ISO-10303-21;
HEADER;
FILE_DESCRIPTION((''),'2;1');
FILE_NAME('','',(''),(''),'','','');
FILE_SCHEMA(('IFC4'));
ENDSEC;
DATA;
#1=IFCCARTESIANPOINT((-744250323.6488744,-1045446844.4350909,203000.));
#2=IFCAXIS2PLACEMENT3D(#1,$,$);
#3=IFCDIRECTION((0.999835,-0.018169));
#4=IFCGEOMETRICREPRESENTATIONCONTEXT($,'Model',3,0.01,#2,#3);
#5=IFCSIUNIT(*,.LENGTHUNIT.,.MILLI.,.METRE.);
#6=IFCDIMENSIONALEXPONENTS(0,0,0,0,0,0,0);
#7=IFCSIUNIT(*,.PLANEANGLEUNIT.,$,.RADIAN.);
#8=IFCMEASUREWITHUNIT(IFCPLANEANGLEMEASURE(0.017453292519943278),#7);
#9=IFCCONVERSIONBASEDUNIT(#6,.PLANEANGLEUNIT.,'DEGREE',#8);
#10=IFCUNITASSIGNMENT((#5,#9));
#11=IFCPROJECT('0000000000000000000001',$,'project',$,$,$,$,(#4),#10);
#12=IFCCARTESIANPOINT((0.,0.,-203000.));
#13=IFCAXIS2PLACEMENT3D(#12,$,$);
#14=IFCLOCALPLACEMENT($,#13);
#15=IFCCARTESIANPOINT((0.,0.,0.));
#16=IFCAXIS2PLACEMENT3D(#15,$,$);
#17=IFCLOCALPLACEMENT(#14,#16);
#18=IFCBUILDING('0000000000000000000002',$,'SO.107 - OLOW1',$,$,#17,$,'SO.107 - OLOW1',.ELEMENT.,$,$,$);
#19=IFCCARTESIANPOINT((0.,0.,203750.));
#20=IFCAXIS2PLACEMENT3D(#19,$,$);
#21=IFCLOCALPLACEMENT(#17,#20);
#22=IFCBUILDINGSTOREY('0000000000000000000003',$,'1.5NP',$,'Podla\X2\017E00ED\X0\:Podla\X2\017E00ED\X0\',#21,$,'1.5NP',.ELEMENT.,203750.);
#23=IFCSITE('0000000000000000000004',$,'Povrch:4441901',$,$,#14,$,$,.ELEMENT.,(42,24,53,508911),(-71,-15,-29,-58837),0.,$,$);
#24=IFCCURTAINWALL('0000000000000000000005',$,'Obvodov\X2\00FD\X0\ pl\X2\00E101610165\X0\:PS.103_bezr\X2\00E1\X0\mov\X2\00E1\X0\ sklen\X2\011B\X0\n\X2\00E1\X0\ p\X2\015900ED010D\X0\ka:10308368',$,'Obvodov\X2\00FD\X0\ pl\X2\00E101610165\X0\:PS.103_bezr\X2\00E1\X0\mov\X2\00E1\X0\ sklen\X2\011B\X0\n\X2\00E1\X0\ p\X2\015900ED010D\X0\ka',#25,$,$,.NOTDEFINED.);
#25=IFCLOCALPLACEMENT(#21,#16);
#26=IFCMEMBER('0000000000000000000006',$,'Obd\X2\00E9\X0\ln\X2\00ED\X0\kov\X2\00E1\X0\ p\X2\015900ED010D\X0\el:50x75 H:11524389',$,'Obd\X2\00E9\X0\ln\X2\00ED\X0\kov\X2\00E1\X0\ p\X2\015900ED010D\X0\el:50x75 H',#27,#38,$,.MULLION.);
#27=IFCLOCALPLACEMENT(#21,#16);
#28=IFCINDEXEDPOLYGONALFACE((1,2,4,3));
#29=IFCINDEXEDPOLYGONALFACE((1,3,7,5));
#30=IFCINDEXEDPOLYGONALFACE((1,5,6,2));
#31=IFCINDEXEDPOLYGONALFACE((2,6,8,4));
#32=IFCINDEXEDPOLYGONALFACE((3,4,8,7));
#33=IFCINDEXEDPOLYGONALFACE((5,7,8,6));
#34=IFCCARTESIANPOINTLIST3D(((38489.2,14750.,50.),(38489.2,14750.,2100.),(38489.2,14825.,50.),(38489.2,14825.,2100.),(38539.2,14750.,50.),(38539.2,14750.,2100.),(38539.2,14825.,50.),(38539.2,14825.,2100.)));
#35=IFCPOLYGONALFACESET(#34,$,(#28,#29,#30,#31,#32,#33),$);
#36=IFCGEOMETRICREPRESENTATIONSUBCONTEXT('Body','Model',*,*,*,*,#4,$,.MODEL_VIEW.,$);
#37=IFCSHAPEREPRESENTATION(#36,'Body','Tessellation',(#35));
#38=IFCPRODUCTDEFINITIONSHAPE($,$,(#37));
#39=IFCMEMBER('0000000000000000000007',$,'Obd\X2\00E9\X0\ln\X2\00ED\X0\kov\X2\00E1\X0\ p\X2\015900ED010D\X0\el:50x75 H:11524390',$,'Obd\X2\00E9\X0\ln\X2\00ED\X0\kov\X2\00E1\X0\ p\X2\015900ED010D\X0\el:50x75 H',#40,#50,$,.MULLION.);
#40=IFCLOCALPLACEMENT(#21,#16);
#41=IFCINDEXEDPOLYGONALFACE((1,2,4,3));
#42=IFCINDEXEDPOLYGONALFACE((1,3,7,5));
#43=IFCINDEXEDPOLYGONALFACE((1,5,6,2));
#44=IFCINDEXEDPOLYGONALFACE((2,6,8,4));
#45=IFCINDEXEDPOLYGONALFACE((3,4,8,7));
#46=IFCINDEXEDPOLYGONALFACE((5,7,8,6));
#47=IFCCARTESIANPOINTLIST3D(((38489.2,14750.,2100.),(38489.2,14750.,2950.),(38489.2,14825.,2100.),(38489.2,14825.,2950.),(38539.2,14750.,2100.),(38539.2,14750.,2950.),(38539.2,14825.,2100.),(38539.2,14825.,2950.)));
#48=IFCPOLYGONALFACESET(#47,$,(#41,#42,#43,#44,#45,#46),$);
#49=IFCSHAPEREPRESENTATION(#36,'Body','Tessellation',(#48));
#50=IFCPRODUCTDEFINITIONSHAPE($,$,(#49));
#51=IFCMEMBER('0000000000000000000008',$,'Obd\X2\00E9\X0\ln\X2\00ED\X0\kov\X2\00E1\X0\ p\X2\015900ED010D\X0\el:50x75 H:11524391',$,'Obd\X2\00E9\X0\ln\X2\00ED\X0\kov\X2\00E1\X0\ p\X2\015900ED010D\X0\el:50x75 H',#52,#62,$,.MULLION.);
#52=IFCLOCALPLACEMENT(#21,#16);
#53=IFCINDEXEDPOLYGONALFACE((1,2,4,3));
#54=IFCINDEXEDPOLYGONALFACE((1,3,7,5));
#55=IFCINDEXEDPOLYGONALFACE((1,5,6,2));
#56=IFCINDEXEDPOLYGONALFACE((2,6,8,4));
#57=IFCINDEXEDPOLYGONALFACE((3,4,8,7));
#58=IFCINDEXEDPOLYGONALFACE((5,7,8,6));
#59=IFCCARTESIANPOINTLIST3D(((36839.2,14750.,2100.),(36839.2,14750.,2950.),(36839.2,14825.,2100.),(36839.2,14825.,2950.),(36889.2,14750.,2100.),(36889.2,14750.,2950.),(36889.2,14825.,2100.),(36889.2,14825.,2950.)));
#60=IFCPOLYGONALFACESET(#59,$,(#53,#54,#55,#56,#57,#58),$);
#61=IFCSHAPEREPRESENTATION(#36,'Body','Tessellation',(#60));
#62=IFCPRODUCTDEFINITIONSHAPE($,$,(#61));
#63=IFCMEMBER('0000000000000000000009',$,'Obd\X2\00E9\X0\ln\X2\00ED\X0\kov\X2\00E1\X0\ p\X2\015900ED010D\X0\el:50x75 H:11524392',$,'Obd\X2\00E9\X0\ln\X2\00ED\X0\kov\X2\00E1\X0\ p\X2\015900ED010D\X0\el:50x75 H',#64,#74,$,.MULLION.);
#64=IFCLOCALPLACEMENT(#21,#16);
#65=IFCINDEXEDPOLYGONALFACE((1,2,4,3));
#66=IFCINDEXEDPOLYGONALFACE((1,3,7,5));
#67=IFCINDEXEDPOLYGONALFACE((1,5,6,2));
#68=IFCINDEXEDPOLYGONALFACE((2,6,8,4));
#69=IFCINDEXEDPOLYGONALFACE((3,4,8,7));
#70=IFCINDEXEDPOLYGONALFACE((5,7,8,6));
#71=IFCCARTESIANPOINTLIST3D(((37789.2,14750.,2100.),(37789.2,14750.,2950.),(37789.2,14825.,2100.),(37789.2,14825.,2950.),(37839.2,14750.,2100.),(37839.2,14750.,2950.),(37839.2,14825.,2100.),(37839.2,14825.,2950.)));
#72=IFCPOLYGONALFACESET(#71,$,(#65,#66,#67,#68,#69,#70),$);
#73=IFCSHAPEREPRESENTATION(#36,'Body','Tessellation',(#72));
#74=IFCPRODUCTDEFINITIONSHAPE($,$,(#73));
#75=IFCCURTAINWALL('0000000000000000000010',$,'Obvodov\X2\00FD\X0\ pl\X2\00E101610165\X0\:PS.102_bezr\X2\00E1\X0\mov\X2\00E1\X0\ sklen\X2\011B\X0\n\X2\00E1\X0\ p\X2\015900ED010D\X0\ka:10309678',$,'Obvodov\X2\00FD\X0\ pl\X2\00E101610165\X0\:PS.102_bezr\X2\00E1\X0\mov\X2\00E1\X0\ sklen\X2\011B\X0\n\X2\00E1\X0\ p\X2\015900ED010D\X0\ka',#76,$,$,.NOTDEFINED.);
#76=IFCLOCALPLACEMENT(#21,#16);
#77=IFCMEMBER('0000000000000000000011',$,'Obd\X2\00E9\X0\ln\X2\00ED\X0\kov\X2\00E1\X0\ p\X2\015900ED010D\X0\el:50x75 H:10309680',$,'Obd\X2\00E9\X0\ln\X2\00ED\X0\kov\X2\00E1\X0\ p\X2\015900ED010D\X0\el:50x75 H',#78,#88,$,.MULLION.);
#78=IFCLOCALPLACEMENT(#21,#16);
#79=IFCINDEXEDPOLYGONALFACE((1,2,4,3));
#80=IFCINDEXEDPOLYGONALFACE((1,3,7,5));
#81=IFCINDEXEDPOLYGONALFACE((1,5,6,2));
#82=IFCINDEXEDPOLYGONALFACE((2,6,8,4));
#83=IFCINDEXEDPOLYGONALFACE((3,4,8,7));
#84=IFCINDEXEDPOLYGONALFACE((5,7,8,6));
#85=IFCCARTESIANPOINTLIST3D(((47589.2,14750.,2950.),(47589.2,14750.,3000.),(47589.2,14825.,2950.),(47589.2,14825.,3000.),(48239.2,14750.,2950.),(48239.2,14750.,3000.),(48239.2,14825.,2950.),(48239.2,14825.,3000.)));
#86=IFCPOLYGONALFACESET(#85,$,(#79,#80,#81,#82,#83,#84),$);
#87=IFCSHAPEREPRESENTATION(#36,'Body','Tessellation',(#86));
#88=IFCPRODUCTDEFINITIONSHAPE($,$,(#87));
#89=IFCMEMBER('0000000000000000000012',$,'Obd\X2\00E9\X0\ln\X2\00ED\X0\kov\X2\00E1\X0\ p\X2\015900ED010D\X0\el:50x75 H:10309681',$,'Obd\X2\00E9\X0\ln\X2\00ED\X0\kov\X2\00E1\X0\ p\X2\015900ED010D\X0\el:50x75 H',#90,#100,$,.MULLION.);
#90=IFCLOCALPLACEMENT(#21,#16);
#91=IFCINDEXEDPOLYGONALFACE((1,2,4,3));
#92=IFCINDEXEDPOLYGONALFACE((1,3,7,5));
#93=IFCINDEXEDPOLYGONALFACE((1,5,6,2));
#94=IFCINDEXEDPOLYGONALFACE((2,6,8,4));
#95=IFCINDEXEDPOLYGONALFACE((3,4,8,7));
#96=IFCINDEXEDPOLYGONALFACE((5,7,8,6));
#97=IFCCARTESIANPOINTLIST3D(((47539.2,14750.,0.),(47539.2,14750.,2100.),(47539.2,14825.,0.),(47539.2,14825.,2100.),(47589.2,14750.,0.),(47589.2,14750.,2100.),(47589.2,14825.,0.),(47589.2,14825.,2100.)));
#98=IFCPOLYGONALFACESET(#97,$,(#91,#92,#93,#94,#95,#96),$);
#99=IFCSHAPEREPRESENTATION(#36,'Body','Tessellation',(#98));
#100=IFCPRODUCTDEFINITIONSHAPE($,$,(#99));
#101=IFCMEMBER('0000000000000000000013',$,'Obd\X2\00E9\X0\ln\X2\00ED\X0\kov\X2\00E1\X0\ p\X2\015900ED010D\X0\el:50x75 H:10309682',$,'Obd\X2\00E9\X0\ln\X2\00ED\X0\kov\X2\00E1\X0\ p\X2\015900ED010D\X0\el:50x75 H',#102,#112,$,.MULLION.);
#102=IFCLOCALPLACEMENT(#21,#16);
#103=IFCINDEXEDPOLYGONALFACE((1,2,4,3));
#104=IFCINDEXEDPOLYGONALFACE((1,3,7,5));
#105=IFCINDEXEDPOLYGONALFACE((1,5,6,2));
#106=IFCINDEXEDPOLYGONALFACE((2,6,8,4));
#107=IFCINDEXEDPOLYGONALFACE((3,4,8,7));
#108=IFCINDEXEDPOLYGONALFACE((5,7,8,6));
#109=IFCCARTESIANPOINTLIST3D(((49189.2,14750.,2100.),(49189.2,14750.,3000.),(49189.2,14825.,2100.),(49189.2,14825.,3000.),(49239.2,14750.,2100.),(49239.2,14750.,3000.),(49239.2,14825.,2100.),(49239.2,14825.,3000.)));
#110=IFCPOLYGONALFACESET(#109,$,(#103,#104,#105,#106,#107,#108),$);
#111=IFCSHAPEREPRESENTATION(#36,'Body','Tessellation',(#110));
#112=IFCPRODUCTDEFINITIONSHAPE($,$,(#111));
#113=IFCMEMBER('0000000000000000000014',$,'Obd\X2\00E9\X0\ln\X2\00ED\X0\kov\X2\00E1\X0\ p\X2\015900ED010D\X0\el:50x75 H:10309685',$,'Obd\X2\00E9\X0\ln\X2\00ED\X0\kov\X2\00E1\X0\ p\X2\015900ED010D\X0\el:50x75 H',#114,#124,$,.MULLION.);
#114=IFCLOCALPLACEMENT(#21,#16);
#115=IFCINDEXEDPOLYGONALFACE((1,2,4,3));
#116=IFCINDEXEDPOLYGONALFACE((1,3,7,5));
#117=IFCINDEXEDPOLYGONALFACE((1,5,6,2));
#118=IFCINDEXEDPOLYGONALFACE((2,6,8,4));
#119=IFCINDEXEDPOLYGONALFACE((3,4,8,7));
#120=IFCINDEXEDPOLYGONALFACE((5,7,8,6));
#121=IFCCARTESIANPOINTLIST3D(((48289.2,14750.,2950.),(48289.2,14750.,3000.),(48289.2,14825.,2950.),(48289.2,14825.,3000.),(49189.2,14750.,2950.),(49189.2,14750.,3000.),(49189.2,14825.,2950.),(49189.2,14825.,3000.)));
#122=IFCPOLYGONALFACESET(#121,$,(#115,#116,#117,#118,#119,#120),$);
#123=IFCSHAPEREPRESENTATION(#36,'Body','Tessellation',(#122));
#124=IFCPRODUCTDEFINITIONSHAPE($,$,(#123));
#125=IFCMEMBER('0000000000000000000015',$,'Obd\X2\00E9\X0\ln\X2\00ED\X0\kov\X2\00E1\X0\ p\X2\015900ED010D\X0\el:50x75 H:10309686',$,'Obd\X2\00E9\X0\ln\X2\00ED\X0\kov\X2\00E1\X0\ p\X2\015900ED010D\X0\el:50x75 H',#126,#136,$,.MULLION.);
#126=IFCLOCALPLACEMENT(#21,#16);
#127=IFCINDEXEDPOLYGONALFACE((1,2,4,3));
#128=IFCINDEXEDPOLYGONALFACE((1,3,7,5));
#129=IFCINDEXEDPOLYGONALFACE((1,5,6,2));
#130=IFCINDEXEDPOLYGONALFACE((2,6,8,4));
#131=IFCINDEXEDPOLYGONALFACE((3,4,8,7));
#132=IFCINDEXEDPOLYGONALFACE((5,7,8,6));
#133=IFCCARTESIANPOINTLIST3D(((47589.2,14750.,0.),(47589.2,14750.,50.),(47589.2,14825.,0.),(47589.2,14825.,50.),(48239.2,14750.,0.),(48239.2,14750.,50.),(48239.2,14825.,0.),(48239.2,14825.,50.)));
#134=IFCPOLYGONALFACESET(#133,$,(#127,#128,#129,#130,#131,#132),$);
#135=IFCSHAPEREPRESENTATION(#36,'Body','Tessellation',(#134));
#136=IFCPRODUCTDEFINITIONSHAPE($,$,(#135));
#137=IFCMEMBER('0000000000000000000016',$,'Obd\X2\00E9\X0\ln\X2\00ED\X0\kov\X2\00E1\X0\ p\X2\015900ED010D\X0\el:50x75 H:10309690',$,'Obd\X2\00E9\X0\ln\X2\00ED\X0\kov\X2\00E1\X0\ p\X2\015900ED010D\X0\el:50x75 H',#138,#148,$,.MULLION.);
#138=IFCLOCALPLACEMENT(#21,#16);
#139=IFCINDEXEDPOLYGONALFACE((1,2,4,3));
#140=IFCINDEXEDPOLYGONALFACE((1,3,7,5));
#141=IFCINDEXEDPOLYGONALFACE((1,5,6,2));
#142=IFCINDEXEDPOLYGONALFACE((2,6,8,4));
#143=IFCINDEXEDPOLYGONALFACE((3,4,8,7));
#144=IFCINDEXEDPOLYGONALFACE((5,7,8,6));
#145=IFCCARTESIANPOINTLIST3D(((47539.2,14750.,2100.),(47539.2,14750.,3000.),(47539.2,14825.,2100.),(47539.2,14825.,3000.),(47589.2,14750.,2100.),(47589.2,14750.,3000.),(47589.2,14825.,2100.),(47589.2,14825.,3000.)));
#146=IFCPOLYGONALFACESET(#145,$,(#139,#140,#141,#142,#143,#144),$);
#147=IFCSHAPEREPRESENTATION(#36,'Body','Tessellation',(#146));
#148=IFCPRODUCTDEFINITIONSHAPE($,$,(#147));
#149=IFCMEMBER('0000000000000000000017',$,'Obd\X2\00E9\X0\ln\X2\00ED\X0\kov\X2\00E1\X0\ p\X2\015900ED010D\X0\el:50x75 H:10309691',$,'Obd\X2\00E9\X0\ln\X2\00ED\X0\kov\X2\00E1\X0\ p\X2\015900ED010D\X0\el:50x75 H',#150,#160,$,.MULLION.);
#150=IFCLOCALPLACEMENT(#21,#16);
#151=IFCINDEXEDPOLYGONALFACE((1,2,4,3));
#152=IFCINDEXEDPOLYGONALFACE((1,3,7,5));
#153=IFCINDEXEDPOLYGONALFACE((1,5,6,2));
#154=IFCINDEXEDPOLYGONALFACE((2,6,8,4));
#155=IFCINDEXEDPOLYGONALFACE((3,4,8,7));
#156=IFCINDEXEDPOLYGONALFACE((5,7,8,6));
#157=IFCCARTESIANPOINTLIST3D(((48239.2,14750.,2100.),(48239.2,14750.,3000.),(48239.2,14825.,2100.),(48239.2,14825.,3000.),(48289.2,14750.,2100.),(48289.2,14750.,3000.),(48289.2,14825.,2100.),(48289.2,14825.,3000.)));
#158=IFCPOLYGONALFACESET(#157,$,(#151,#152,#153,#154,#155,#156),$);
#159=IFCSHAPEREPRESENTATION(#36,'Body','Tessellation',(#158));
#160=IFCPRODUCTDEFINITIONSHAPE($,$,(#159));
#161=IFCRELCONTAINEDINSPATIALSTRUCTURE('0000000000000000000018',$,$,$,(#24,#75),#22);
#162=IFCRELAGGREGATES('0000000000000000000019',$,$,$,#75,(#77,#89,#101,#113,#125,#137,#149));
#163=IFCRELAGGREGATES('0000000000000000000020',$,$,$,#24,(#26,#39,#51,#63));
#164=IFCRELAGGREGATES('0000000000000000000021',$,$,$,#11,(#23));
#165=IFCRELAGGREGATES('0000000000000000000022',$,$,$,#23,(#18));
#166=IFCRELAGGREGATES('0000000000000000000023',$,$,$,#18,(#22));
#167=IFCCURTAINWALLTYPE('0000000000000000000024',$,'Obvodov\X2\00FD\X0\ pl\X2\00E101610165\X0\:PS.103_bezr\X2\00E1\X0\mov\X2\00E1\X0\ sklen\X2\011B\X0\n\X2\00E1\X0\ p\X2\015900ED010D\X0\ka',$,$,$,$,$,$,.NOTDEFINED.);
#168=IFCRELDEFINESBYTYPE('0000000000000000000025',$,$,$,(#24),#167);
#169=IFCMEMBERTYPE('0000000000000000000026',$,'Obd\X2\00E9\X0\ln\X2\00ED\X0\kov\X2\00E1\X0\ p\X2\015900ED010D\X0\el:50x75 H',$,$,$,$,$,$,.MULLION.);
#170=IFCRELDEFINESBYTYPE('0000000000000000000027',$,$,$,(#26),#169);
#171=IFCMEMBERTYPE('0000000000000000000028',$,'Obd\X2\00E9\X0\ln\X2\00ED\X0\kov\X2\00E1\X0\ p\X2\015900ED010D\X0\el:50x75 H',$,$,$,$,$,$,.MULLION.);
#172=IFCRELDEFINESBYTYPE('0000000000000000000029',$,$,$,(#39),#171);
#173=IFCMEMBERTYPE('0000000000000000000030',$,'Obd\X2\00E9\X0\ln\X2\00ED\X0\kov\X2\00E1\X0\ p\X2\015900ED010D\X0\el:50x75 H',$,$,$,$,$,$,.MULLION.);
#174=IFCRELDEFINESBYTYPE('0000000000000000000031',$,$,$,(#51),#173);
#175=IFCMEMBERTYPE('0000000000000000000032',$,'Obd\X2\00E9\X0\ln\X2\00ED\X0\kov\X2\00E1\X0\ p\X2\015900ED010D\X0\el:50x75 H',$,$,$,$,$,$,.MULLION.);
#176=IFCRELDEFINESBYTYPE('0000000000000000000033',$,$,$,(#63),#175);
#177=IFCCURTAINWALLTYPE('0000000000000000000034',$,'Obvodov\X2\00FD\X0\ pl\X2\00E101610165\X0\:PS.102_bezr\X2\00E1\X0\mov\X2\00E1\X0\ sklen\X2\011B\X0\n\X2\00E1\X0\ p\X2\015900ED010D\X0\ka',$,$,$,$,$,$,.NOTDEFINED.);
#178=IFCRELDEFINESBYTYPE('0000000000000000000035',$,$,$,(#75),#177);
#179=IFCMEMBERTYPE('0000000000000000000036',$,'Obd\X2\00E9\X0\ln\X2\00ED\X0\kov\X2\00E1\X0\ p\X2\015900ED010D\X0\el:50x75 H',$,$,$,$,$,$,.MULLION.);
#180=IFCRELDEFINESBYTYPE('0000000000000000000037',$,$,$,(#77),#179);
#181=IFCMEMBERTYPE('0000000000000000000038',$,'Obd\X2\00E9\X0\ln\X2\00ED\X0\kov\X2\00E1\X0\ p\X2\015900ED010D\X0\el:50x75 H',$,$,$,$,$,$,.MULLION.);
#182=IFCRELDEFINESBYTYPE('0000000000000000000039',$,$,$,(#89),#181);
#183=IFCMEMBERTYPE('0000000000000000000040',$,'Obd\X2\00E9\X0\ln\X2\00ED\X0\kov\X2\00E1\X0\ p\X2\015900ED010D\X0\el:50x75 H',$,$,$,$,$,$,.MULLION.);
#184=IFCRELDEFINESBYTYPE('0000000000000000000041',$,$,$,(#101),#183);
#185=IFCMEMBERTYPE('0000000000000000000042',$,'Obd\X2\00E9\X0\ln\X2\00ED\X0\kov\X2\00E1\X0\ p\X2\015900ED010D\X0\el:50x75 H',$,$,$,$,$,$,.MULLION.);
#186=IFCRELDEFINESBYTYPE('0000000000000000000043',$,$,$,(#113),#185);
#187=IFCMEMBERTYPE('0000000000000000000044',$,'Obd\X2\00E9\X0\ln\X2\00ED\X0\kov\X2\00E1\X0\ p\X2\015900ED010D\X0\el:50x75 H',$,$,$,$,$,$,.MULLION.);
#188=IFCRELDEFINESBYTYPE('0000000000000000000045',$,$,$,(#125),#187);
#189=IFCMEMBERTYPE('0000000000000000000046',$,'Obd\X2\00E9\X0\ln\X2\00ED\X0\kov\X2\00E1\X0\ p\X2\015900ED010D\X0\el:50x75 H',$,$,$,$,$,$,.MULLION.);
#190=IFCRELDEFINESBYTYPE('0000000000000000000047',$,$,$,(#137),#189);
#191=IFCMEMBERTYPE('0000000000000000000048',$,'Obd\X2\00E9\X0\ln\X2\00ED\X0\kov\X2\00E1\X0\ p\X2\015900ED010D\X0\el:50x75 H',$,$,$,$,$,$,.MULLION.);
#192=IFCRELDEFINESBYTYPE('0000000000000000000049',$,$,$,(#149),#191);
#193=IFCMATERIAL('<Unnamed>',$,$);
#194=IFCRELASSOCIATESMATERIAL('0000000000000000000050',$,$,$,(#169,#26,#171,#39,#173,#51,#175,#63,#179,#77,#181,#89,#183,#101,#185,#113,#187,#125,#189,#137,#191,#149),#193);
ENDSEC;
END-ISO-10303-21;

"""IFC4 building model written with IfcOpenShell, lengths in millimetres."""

from ifc_helpers import new_model, entity, si_unit, converted_unit, direction, frame, origin, place, context, subcontext, project, spatial, indexed_curve, outline, extrude, source, transform, mapped, material, type_object, type_shapes, element, aggregate, save


model = new_model("IFC4")

# Units and contexts
model_context = context("Model", 3, precision=0.01, world=frame((-744250323.6488744, -1045446844.4350909, 203000.0)), true_north=direction((0.999835, -0.018169)))
body_context = subcontext(model_context, "Body", "Model", "MODEL_VIEW")
ifc_project = project(units=[si_unit("LENGTHUNIT", "METRE", prefix="MILLI"), converted_unit("PLANEANGLEUNIT", "DEGREE", entity("IfcPlaneAngleMeasure", 0.017453292519943278), si_unit("PLANEANGLEUNIT", "RADIAN"), dimensions=[0, 0, 0, 0, 0, 0, 0])], contexts=[model_context])

# Site, building, storey
site_placement = place(None, frame((0.0, 0.0, -203000.0)))
site = spatial("IfcSite", under=ifc_project, at=site_placement, Name="Povrch:4441901", CompositionType="ELEMENT", RefLatitude=(42, 24, 53, 508911), RefLongitude=(-71, -15, -29, -58837), RefElevation=0.0)
building_placement = place(site_placement, origin())
building = spatial("IfcBuilding", under=site, at=building_placement, Name="SO.107 - OLOW1", LongName="SO.107 - OLOW1", CompositionType="ELEMENT")
storey_placement = place(building_placement, frame((0.0, 0.0, 203750.0)))
storey = spatial("IfcBuildingStorey", under=building, at=storey_placement, Name="1.5NP", ObjectType="Podlaží:Podlaží", LongName="1.5NP", CompositionType="ELEMENT", Elevation=203750.0)

# Curtain walls, members
ifc_material_1 = material(Name="<Unnamed>")
curtain_wall_type_1 = type_object("IfcCurtainWallType", Name="Obvodový plášť:PS.103_bezrámová skleněná příčka", PredefinedType="NOTDEFINED")
curtain_wall_1_placement = place(storey_placement, frame((0.0, 0.0, -203750.0)))
curtain_wall_1 = element("IfcCurtainWall", 1, at=curtain_wall_1_placement, inside=storey, type_object=curtain_wall_type_1, Name="Obvodový plášť:PS.103_bezrámová skleněná příčka:10308368", ObjectType="Obvodový plášť:PS.103_bezrámová skleněná příčka", PredefinedType="NOTDEFINED")
member_type_1 = type_object("IfcMemberType", Name="Obdélníková příčel:50x75 H", PredefinedType="MULLION", material=ifc_material_1)
shared_shape_1 = source(origin(), body_context, "Body", "SweptSolid", [
    extrude(outline(indexed_curve([(-25.0, -37.5), (25.0, -37.5), (25.0, 37.5), (-25.0, 37.5), (-25.0, -37.5)], self_intersect=False)), frame((-25.0, -37.5, -2050.0), z_axis=(0.0, 0.0, 1.0), x_axis=(-1.0, 0.0, 0.0)), (0.0, 0.0, 1.0), 2050.0),
])
type_shapes(member_type_1, [shared_shape_1])
member_1_placement = place(curtain_wall_1_placement, frame((38539.2, 14750.0, 203800.0), z_axis=(0.0, 0.0, -1.0), x_axis=(1.0, 0.0, 0.0)))
member_1 = element("IfcMember", 2, at=member_1_placement, type_object=member_type_1, material=ifc_material_1, Name="Obdélníková příčel:50x75 H:11524389", ObjectType="Obdélníková příčel:50x75 H", PredefinedType="MULLION", context=body_context, shape_type="MappedRepresentation", body=[
    mapped(shared_shape_1, transform((0.0, 0.0, 0.0), scale=1.0)),
])
member_type_2 = type_object("IfcMemberType", Name="Obdélníková příčel:50x75 H", PredefinedType="MULLION", material=ifc_material_1)
shared_shape_2 = source(origin(), body_context, "Body", "SweptSolid", [
    extrude(outline(indexed_curve([(-25.0, -37.5), (25.0, -37.5), (25.0, 37.5), (-25.0, 37.5), (-25.0, -37.5)], self_intersect=False)), frame((-25.0, -37.5, -850.0), z_axis=(0.0, 0.0, 1.0), x_axis=(-1.0, 0.0, 0.0)), (0.0, 0.0, 1.0), 850.0),
])
type_shapes(member_type_2, [shared_shape_2])
member_2_placement = place(curtain_wall_1_placement, frame((38539.2, 14750.0, 205850.0), z_axis=(0.0, 0.0, -1.0), x_axis=(1.0, 0.0, 0.0)))
member_2 = element("IfcMember", 3, at=member_2_placement, type_object=member_type_2, material=ifc_material_1, Name="Obdélníková příčel:50x75 H:11524390", ObjectType="Obdélníková příčel:50x75 H", PredefinedType="MULLION", context=body_context, shape_type="MappedRepresentation", body=[
    mapped(shared_shape_2, transform((0.0, 0.0, 0.0), scale=1.0)),
])
member_type_3 = type_object("IfcMemberType", Name="Obdélníková příčel:50x75 H", PredefinedType="MULLION", material=ifc_material_1)
shared_shape_3 = source(origin(), body_context, "Body", "SweptSolid", [
    extrude(outline(indexed_curve([(-25.0, -37.5), (25.0, -37.5), (25.0, 37.5), (-25.0, 37.5), (-25.0, -37.5)], self_intersect=False)), frame((-25.0, -37.5, -850.0), z_axis=(0.0, 0.0, 1.0), x_axis=(-1.0, 0.0, 0.0)), (0.0, 0.0, 1.0), 850.0),
])
type_shapes(member_type_3, [shared_shape_3])
member_3_placement = place(curtain_wall_1_placement, frame((36839.2, 14750.0, 206700.0), z_axis=(0.0, 0.0, 1.0), x_axis=(-1.0, 0.0, 0.0)))
member_3 = element("IfcMember", 4, at=member_3_placement, type_object=member_type_3, material=ifc_material_1, Name="Obdélníková příčel:50x75 H:11524391", ObjectType="Obdélníková příčel:50x75 H", PredefinedType="MULLION", context=body_context, shape_type="MappedRepresentation", body=[
    mapped(shared_shape_3, transform((0.0, 0.0, 0.0), scale=1.0)),
])
member_type_4 = type_object("IfcMemberType", Name="Obdélníková příčel:50x75 H", PredefinedType="MULLION", material=ifc_material_1)
shared_shape_4 = source(origin(), body_context, "Body", "SweptSolid", [
    extrude(outline(indexed_curve([(-25.0, -37.5), (25.0, -37.5), (25.0, 37.5), (-25.0, 37.5), (-25.0, -37.5)], self_intersect=False)), frame((-25.0, -37.5, -850.0), z_axis=(0.0, 0.0, 1.0), x_axis=(-1.0, 0.0, 0.0)), (0.0, 0.0, 1.0), 850.0),
])
type_shapes(member_type_4, [shared_shape_4])
member_4_placement = place(curtain_wall_1_placement, frame((37839.2, 14750.0, 205850.0), z_axis=(0.0, 0.0, -1.0), x_axis=(1.0, 0.0, 0.0)))
member_4 = element("IfcMember", 5, at=member_4_placement, type_object=member_type_4, material=ifc_material_1, Name="Obdélníková příčel:50x75 H:11524392", ObjectType="Obdélníková příčel:50x75 H", PredefinedType="MULLION", context=body_context, shape_type="MappedRepresentation", body=[
    mapped(shared_shape_4, transform((0.0, 0.0, 0.0), scale=1.0)),
])
curtain_wall_type_2 = type_object("IfcCurtainWallType", Name="Obvodový plášť:PS.102_bezrámová skleněná příčka", PredefinedType="NOTDEFINED")
curtain_wall_2_placement = place(storey_placement, frame((0.0, 0.0, -203750.0)))
curtain_wall_2 = element("IfcCurtainWall", 6, at=curtain_wall_2_placement, inside=storey, type_object=curtain_wall_type_2, Name="Obvodový plášť:PS.102_bezrámová skleněná příčka:10309678", ObjectType="Obvodový plášť:PS.102_bezrámová skleněná příčka", PredefinedType="NOTDEFINED")
member_type_5 = type_object("IfcMemberType", Name="Obdélníková příčel:50x75 H", PredefinedType="MULLION", material=ifc_material_1)
shared_shape_5 = source(origin(), body_context, "Body", "SweptSolid", [
    extrude(outline(indexed_curve([(-25.0, -37.5), (25.0, -37.5), (25.0, 37.5), (-25.0, 37.5), (-25.0, -37.5)], self_intersect=False)), frame((-25.0, 37.5, -650.0), z_axis=(0.0, 0.0, 1.0), x_axis=(-1.0, 0.0, 0.0)), (0.0, 0.0, 1.0), 650.0),
])
type_shapes(member_type_5, [shared_shape_5])
member_5_placement = place(curtain_wall_2_placement, frame((47589.2, 14750.0, 206750.0), z_axis=(-1.0, 0.0, 0.0), x_axis=(0.0, 0.0, 1.0)))
member_5 = element("IfcMember", 7, at=member_5_placement, type_object=member_type_5, material=ifc_material_1, Name="Obdélníková příčel:50x75 H:10309680", ObjectType="Obdélníková příčel:50x75 H", PredefinedType="MULLION", context=body_context, shape_type="MappedRepresentation", body=[
    mapped(shared_shape_5, transform((0.0, 0.0, 0.0), scale=1.0)),
])
member_type_6 = type_object("IfcMemberType", Name="Obdélníková příčel:50x75 H", PredefinedType="MULLION", material=ifc_material_1)
shared_shape_6 = source(origin(), body_context, "Body", "SweptSolid", [
    extrude(outline(indexed_curve([(-25.0, -37.5), (25.0, -37.5), (25.0, 37.5), (-25.0, 37.5), (-25.0, -37.5)], self_intersect=False)), frame((-25.0, 37.5, -2100.0), z_axis=(0.0, 0.0, 1.0), x_axis=(-1.0, 0.0, 0.0)), (0.0, 0.0, 1.0), 2100.0),
])
type_shapes(member_type_6, [shared_shape_6])
member_6_placement = place(curtain_wall_2_placement, frame((47539.2, 14750.0, 203750.0), z_axis=(0.0, 0.0, -1.0), x_axis=(-1.0, 0.0, 0.0)))
member_6 = element("IfcMember", 8, at=member_6_placement, type_object=member_type_6, material=ifc_material_1, Name="Obdélníková příčel:50x75 H:10309681", ObjectType="Obdélníková příčel:50x75 H", PredefinedType="MULLION", context=body_context, shape_type="MappedRepresentation", body=[
    mapped(shared_shape_6, transform((0.0, 0.0, 0.0), scale=1.0)),
])
member_type_7 = type_object("IfcMemberType", Name="Obdélníková příčel:50x75 H", PredefinedType="MULLION", material=ifc_material_1)
shared_shape_7 = source(origin(), body_context, "Body", "SweptSolid", [
    extrude(outline(indexed_curve([(-25.0, -37.5), (25.0, -37.5), (25.0, 37.5), (-25.0, 37.5), (-25.0, -37.5)], self_intersect=False)), frame((-25.0, 37.5, -900.0), z_axis=(0.0, 0.0, 1.0), x_axis=(-1.0, 0.0, 0.0)), (0.0, 0.0, 1.0), 900.0),
])
type_shapes(member_type_7, [shared_shape_7])
member_7_placement = place(curtain_wall_2_placement, frame((49239.2, 14750.0, 206750.0)))
member_7 = element("IfcMember", 9, at=member_7_placement, type_object=member_type_7, material=ifc_material_1, Name="Obdélníková příčel:50x75 H:10309682", ObjectType="Obdélníková příčel:50x75 H", PredefinedType="MULLION", context=body_context, shape_type="MappedRepresentation", body=[
    mapped(shared_shape_7, transform((0.0, 0.0, 0.0), scale=1.0)),
])
member_type_8 = type_object("IfcMemberType", Name="Obdélníková příčel:50x75 H", PredefinedType="MULLION", material=ifc_material_1)
shared_shape_8 = source(origin(), body_context, "Body", "SweptSolid", [
    extrude(outline(indexed_curve([(-25.0, -37.5), (25.0, -37.5), (25.0, 37.5), (-25.0, 37.5), (-25.0, -37.5)], self_intersect=False)), frame((-25.0, 37.5, -900.0), z_axis=(0.0, 0.0, 1.0), x_axis=(-1.0, 0.0, 0.0)), (0.0, 0.0, 1.0), 900.0),
])
type_shapes(member_type_8, [shared_shape_8])
member_8_placement = place(curtain_wall_2_placement, frame((48289.2, 14750.0, 206750.0), z_axis=(-1.0, 0.0, 0.0), x_axis=(0.0, 0.0, 1.0)))
member_8 = element("IfcMember", 10, at=member_8_placement, type_object=member_type_8, material=ifc_material_1, Name="Obdélníková příčel:50x75 H:10309685", ObjectType="Obdélníková příčel:50x75 H", PredefinedType="MULLION", context=body_context, shape_type="MappedRepresentation", body=[
    mapped(shared_shape_8, transform((0.0, 0.0, 0.0), scale=1.0)),
])
member_type_9 = type_object("IfcMemberType", Name="Obdélníková příčel:50x75 H", PredefinedType="MULLION", material=ifc_material_1)
shared_shape_9 = source(origin(), body_context, "Body", "SweptSolid", [
    extrude(outline(indexed_curve([(-25.0, -37.5), (25.0, -37.5), (25.0, 37.5), (-25.0, 37.5), (-25.0, -37.5)], self_intersect=False)), frame((-25.0, 37.5, -650.0), z_axis=(0.0, 0.0, 1.0), x_axis=(-1.0, 0.0, 0.0)), (0.0, 0.0, 1.0), 650.0),
])
type_shapes(member_type_9, [shared_shape_9])
member_9_placement = place(curtain_wall_2_placement, frame((48239.2, 14750.0, 203750.0), z_axis=(1.0, 0.0, 0.0), x_axis=(0.0, 0.0, -1.0)))
member_9 = element("IfcMember", 11, at=member_9_placement, type_object=member_type_9, material=ifc_material_1, Name="Obdélníková příčel:50x75 H:10309686", ObjectType="Obdélníková příčel:50x75 H", PredefinedType="MULLION", context=body_context, shape_type="MappedRepresentation", body=[
    mapped(shared_shape_9, transform((0.0, 0.0, 0.0), scale=1.0)),
])
member_type_10 = type_object("IfcMemberType", Name="Obdélníková příčel:50x75 H", PredefinedType="MULLION", material=ifc_material_1)
shared_shape_10 = source(origin(), body_context, "Body", "SweptSolid", [
    extrude(outline(indexed_curve([(-25.0, -37.5), (25.0, -37.5), (25.0, 37.5), (-25.0, 37.5), (-25.0, -37.5)], self_intersect=False)), frame((-25.0, 37.5, -900.0), z_axis=(0.0, 0.0, 1.0), x_axis=(-1.0, 0.0, 0.0)), (0.0, 0.0, 1.0), 900.0),
])
type_shapes(member_type_10, [shared_shape_10])
member_10_placement = place(curtain_wall_2_placement, frame((47539.2, 14750.0, 205850.0), z_axis=(0.0, 0.0, -1.0), x_axis=(-1.0, 0.0, 0.0)))
member_10 = element("IfcMember", 12, at=member_10_placement, type_object=member_type_10, material=ifc_material_1, Name="Obdélníková příčel:50x75 H:10309690", ObjectType="Obdélníková příčel:50x75 H", PredefinedType="MULLION", context=body_context, shape_type="MappedRepresentation", body=[
    mapped(shared_shape_10, transform((0.0, 0.0, 0.0), scale=1.0)),
])
member_type_11 = type_object("IfcMemberType", Name="Obdélníková příčel:50x75 H", PredefinedType="MULLION", material=ifc_material_1)
shared_shape_11 = source(origin(), body_context, "Body", "SweptSolid", [
    extrude(outline(indexed_curve([(-25.0, -37.5), (25.0, -37.5), (25.0, 37.5), (-25.0, 37.5), (-25.0, -37.5)], self_intersect=False)), frame((-25.0, 37.5, -900.0), z_axis=(0.0, 0.0, 1.0), x_axis=(-1.0, 0.0, 0.0)), (0.0, 0.0, 1.0), 900.0),
])
type_shapes(member_type_11, [shared_shape_11])
member_11_placement = place(curtain_wall_2_placement, frame((48239.2, 14750.0, 205850.0), z_axis=(0.0, 0.0, -1.0), x_axis=(-1.0, 0.0, 0.0)))
member_11 = element("IfcMember", 13, at=member_11_placement, type_object=member_type_11, material=ifc_material_1, Name="Obdélníková příčel:50x75 H:10309691", ObjectType="Obdélníková příčel:50x75 H", PredefinedType="MULLION", context=body_context, shape_type="MappedRepresentation", body=[
    mapped(shared_shape_11, transform((0.0, 0.0, 0.0), scale=1.0)),
])

aggregate(curtain_wall_2, [member_5, member_6, member_7, member_8, member_9, member_10, member_11])
aggregate(curtain_wall_1, [member_1, member_2, member_3, member_4])

save(model, "model.ifc")
